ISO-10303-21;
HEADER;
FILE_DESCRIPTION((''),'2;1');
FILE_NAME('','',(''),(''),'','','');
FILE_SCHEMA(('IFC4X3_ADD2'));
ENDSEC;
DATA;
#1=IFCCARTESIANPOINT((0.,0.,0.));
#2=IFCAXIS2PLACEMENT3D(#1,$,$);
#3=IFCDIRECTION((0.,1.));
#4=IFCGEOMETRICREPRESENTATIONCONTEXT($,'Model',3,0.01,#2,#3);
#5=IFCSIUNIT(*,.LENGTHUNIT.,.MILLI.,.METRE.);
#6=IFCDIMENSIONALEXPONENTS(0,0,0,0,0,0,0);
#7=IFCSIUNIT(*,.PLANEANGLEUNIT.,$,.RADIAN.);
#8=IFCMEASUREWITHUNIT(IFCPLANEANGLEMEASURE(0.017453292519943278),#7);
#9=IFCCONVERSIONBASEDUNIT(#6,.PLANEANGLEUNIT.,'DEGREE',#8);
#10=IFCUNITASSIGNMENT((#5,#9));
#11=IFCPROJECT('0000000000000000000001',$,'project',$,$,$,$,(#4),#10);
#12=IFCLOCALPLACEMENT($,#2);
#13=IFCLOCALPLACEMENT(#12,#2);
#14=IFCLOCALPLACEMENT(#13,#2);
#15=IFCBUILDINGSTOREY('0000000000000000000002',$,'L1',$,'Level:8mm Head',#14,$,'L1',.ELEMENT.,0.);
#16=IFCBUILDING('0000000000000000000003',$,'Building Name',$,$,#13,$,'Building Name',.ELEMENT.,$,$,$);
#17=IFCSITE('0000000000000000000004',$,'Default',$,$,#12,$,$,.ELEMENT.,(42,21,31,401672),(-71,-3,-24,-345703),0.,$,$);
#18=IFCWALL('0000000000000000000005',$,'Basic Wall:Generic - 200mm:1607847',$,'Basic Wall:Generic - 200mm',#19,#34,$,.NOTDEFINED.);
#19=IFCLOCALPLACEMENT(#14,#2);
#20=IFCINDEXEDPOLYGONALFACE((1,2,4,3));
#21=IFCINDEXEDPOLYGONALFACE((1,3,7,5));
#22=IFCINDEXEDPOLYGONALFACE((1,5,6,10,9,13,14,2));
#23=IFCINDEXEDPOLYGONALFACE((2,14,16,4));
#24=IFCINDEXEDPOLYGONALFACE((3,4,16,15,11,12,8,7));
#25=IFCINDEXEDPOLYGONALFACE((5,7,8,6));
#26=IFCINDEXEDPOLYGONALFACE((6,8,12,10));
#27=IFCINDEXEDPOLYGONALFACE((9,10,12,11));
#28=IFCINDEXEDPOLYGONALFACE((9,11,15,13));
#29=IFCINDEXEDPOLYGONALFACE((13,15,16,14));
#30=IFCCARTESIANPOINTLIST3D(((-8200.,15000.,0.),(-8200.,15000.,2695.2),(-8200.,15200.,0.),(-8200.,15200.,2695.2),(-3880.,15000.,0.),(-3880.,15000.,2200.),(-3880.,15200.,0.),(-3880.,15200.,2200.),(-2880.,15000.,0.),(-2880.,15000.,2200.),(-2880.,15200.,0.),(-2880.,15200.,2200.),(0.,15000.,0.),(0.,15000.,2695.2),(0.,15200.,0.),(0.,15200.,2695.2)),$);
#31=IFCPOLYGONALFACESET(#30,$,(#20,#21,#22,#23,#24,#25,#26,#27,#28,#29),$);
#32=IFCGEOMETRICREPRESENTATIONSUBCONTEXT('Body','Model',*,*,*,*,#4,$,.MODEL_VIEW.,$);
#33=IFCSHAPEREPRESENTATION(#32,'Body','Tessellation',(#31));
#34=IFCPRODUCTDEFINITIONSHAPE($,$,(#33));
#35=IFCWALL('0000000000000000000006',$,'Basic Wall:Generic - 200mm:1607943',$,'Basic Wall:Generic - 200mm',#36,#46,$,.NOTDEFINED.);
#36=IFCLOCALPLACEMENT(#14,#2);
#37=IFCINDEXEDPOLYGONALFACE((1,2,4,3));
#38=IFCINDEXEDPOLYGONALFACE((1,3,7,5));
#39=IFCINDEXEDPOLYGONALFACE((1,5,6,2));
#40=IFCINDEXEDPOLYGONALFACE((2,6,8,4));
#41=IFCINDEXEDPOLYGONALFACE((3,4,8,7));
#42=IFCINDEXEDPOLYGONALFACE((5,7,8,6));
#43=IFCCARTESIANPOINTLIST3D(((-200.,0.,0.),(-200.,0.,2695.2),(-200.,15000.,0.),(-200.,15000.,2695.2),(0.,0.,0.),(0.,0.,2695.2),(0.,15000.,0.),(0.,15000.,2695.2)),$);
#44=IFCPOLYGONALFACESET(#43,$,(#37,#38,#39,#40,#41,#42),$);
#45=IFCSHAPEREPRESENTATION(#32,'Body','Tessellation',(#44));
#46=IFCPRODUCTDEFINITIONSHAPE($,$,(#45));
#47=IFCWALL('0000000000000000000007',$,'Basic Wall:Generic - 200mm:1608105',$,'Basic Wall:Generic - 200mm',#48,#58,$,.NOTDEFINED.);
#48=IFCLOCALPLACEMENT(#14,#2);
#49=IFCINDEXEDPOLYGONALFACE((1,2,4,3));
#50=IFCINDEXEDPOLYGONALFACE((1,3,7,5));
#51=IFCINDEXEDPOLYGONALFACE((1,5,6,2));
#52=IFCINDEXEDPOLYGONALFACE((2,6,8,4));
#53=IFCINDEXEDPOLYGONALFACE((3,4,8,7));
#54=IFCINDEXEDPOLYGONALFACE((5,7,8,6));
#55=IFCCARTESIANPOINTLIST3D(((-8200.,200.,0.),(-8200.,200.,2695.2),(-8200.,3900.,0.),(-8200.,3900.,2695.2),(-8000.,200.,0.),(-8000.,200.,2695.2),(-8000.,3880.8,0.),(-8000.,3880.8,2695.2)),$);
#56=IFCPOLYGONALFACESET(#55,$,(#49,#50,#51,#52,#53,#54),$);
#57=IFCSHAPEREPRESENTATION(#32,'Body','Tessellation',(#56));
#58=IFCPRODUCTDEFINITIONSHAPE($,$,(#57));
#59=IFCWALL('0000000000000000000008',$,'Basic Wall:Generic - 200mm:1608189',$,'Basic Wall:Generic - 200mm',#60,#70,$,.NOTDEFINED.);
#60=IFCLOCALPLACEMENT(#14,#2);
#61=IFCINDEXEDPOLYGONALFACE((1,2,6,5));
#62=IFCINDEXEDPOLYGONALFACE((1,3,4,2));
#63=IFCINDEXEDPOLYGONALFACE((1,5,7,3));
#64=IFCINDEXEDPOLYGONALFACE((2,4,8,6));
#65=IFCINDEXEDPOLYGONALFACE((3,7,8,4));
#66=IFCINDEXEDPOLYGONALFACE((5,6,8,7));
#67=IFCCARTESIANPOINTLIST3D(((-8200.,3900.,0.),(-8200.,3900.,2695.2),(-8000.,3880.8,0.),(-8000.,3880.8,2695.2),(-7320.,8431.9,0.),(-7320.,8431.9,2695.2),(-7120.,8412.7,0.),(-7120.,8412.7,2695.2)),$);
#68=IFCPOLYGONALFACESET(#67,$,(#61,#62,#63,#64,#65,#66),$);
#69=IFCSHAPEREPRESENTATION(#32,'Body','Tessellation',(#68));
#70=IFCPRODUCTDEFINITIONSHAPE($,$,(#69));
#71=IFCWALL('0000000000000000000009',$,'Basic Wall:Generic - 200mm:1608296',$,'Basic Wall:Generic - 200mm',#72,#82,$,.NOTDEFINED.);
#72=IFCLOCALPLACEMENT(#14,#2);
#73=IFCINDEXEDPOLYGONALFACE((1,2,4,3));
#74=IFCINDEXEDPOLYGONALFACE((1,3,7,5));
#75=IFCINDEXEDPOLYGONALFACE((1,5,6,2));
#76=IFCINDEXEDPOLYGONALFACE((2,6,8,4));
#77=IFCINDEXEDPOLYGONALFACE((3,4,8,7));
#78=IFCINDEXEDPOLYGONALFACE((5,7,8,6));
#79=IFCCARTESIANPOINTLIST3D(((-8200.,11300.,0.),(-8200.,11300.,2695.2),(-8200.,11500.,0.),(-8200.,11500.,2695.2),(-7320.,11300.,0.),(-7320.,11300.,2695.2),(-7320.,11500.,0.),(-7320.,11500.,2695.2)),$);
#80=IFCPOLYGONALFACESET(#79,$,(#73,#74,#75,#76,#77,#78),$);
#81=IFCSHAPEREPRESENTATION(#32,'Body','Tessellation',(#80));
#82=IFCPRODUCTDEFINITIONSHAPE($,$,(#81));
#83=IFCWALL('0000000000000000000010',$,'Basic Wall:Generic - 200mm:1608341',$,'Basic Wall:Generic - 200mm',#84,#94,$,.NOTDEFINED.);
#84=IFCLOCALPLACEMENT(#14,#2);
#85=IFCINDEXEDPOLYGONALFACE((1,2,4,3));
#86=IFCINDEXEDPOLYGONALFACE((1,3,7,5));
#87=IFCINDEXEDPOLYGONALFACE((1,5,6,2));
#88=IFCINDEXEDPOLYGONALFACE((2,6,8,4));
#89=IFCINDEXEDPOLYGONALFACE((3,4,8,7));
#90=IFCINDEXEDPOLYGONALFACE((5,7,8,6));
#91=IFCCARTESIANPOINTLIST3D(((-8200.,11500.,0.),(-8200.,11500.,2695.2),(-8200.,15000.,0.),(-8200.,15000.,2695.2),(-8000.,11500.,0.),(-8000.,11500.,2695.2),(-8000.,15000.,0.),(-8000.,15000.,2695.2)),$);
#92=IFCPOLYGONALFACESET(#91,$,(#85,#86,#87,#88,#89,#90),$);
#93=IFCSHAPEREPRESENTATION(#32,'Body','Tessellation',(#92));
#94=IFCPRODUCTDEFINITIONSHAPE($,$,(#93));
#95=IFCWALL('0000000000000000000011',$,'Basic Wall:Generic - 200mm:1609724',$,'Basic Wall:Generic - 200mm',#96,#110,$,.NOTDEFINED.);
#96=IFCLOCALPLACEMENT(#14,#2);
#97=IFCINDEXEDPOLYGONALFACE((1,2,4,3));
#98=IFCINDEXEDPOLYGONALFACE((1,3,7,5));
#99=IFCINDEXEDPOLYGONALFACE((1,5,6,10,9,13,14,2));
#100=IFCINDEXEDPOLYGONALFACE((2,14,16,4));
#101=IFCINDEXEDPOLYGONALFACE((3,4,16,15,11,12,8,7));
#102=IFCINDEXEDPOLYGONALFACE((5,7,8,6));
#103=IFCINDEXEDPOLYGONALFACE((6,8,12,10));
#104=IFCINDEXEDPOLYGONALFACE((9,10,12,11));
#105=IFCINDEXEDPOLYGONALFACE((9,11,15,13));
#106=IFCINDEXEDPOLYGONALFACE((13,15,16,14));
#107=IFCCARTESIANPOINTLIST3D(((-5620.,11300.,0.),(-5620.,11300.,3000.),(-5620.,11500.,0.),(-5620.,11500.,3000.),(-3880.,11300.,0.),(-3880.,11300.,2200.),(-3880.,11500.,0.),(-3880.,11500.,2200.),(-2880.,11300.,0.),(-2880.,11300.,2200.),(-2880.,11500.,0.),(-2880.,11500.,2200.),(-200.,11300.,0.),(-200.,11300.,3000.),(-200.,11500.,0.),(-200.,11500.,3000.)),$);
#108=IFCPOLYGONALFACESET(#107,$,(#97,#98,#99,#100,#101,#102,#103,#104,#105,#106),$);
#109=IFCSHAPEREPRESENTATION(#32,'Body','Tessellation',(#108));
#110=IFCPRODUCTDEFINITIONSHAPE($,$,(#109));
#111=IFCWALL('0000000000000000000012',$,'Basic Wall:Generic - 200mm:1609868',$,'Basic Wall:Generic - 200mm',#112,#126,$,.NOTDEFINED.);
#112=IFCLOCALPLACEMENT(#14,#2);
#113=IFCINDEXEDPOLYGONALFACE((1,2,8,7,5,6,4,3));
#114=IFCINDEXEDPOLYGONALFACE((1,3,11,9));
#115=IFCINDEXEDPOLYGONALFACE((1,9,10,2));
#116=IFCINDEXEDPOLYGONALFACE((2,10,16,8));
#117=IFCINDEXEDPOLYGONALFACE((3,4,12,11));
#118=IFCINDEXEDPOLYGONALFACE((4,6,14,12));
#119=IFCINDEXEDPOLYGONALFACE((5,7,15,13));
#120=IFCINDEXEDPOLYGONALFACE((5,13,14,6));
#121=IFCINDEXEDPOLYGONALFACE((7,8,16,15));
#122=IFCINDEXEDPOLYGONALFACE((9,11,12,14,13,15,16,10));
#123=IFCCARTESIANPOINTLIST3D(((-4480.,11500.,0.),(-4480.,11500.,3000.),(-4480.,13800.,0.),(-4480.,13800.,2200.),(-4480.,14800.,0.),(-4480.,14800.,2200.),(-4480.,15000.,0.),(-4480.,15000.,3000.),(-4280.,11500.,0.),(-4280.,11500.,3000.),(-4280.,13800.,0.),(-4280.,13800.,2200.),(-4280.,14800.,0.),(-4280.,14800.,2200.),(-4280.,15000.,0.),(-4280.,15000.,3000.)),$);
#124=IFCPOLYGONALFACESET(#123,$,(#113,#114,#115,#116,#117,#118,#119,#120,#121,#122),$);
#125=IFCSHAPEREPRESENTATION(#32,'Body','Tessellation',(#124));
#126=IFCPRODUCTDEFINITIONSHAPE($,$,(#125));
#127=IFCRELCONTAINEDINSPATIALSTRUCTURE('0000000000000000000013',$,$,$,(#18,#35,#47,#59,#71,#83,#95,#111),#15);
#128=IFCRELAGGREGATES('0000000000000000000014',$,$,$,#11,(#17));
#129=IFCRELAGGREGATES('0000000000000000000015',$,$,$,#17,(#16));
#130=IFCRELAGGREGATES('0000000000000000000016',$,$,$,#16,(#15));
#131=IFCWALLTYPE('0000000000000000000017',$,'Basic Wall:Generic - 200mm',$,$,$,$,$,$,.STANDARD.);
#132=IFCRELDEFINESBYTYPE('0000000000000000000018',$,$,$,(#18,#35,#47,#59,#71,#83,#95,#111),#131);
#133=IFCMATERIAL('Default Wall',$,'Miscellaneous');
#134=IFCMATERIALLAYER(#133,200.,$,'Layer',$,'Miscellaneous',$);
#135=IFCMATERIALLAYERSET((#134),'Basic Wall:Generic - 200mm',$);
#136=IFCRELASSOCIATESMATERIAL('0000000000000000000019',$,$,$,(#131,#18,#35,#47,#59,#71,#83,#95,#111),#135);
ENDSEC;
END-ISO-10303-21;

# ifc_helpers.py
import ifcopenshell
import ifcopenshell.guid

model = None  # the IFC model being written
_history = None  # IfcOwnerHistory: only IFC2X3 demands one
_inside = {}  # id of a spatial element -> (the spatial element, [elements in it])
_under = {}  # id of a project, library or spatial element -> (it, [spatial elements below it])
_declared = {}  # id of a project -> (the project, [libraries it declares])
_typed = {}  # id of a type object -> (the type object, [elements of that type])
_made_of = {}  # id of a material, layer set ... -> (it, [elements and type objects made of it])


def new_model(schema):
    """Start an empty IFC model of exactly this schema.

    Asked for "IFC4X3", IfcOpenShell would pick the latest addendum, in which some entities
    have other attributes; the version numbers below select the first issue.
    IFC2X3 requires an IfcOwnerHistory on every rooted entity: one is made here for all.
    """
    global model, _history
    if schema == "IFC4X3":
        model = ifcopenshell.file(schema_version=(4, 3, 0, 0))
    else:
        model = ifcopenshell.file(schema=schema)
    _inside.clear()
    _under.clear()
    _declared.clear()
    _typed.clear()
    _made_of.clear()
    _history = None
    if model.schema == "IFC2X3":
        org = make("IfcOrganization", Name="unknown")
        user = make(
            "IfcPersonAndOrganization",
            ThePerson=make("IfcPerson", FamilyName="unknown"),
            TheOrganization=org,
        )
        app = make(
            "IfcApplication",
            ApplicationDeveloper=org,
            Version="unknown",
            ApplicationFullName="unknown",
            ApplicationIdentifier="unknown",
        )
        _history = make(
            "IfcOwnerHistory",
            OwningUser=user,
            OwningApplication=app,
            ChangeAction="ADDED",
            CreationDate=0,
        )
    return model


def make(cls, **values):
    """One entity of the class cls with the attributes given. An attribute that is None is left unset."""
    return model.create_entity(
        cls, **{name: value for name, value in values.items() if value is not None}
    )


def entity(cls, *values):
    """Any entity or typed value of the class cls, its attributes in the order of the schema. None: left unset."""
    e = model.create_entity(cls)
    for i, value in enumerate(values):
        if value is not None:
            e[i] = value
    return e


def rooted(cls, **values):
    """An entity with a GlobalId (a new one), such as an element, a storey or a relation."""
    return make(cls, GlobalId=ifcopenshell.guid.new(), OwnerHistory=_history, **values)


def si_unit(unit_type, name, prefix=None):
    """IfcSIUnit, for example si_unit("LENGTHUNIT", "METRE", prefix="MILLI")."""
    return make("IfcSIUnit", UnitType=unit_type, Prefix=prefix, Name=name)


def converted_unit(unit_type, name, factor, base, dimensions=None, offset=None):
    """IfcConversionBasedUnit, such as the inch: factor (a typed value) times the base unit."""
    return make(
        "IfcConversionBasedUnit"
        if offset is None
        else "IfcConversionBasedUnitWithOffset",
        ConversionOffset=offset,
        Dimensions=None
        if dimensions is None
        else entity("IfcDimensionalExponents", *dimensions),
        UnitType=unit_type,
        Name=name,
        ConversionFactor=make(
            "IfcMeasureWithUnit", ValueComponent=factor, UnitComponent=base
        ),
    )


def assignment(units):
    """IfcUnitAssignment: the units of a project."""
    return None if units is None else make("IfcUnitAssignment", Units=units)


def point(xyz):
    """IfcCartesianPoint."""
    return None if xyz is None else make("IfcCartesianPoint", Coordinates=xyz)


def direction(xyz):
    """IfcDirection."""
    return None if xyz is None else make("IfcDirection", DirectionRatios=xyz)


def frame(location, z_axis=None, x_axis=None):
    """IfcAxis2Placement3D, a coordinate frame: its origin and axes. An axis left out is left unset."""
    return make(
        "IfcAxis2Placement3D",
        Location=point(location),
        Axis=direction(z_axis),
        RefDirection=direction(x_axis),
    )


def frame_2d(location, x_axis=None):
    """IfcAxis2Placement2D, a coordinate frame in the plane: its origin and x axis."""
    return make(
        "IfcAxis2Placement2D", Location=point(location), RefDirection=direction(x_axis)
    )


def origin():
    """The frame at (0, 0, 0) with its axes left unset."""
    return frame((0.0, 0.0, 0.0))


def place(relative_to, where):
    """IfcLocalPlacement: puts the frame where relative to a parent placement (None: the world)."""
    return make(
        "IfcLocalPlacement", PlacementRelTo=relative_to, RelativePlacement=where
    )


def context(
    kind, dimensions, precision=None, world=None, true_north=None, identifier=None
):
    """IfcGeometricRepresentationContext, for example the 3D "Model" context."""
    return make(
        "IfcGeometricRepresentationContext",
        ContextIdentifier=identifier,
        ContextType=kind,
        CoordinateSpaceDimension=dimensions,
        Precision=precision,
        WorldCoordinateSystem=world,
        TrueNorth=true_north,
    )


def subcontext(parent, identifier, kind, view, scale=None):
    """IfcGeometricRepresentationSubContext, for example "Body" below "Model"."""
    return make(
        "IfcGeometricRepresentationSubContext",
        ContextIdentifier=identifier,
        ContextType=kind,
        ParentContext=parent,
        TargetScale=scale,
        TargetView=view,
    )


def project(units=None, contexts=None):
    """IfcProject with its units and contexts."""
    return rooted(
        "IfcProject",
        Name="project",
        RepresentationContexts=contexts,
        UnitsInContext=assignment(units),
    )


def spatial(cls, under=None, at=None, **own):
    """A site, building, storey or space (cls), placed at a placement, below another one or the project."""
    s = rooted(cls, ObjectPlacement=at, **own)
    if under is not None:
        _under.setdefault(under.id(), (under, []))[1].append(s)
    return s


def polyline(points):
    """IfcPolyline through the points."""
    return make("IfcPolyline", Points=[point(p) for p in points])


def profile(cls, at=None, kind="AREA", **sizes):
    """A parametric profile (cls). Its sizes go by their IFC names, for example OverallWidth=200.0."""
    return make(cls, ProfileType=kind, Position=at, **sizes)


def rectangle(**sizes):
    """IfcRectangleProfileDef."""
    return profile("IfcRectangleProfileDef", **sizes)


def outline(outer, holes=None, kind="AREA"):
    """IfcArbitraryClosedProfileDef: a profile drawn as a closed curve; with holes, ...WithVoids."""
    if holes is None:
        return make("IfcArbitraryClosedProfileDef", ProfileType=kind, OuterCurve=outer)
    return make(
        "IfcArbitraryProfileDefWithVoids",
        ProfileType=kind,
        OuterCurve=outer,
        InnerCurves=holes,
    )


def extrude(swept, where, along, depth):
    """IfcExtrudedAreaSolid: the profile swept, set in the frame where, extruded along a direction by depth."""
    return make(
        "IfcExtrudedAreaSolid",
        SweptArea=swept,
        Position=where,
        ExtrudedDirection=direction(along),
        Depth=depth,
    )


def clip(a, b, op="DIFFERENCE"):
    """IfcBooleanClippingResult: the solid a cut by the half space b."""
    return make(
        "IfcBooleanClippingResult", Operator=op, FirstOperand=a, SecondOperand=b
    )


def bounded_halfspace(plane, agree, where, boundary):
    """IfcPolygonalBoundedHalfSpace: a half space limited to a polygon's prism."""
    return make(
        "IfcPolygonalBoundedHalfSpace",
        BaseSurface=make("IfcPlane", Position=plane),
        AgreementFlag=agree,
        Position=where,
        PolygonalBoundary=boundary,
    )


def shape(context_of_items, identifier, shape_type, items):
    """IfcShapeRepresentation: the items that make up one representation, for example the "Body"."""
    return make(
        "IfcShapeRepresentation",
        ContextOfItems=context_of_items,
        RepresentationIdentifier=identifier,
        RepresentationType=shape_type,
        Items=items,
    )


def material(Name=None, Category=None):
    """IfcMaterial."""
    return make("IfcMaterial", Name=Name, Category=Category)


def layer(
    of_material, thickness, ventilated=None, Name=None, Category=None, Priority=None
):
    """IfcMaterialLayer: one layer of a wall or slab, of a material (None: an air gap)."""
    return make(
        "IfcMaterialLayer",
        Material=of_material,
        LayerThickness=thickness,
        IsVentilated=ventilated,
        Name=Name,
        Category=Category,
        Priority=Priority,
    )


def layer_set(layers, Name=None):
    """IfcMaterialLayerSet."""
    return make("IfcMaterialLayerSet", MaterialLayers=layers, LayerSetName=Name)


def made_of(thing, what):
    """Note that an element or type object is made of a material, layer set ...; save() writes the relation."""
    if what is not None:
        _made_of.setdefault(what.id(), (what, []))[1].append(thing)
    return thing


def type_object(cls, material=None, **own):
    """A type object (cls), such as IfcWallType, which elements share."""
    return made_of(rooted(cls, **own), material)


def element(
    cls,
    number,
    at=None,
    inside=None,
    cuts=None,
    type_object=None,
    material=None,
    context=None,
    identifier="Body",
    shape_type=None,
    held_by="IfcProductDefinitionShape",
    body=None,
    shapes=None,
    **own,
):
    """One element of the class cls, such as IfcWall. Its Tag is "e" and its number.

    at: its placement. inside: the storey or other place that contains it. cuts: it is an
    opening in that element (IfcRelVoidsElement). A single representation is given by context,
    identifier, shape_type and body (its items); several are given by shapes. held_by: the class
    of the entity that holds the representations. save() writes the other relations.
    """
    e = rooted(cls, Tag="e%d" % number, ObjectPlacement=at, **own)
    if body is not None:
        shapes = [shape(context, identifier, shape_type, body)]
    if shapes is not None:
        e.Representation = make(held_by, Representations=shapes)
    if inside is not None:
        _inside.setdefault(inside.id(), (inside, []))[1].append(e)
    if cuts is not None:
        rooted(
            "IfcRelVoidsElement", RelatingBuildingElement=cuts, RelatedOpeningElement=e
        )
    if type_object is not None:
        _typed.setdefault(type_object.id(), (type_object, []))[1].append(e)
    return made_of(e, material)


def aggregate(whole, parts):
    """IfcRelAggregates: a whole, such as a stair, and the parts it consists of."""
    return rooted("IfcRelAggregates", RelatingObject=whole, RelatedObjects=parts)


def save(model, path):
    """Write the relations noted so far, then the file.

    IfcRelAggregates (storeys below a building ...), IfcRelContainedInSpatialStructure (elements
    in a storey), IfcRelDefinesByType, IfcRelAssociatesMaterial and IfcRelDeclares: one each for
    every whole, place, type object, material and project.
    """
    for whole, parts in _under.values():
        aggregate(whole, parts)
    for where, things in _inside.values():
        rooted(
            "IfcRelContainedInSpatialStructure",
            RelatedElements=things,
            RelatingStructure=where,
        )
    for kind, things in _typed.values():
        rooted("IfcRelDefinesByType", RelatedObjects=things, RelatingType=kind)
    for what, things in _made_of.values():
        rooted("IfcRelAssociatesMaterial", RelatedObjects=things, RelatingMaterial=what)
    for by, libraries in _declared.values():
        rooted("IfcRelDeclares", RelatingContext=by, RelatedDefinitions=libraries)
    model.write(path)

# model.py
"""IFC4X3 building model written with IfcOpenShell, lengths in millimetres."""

from ifc_helpers import new_model, entity, si_unit, converted_unit, direction, frame, frame_2d, origin, place, context, subcontext, project, spatial, polyline, rectangle, outline, extrude, clip, bounded_halfspace, material, layer, layer_set, type_object, element, save


model = new_model("IFC4X3")

# Units and contexts
model_context = context("Model", 3, precision=0.01, world=origin(), true_north=direction((0.0, 1.0)))
body_context = subcontext(model_context, "Body", "Model", "MODEL_VIEW")
ifc_project = project(units=[si_unit("LENGTHUNIT", "METRE", prefix="MILLI"), converted_unit("PLANEANGLEUNIT", "DEGREE", entity("IfcPlaneAngleMeasure", 0.017453292519943278), si_unit("PLANEANGLEUNIT", "RADIAN"), dimensions=[0, 0, 0, 0, 0, 0, 0])], contexts=[model_context])

# Site, building, storey
site_placement = place(None, origin())
site = spatial("IfcSite", under=ifc_project, at=site_placement, Name="Default", CompositionType="ELEMENT", RefLatitude=(42, 21, 31, 401672), RefLongitude=(-71, -3, -24, -345703), RefElevation=0.0)
building_placement = place(site_placement, origin())
building = spatial("IfcBuilding", under=site, at=building_placement, Name="Building Name", LongName="Building Name", CompositionType="ELEMENT")
storey_placement = place(building_placement, origin())
storey = spatial("IfcBuildingStorey", under=building, at=storey_placement, Name="L1", ObjectType="Level:8mm Head", LongName="L1", CompositionType="ELEMENT", Elevation=0.0)

# Wall, opening
ifc_material = material(Name="Default Wall", Category="Miscellaneous")
ifc_layer = layer(ifc_material, 200.0, Name="Layer", Category="Miscellaneous")
ifc_layer_set = layer_set([ifc_layer], Name="Basic Wall:Generic - 200mm")
wall_type = type_object("IfcWallType", Name="Basic Wall:Generic - 200mm", PredefinedType="STANDARD", material=ifc_layer_set)
wall_1_placement = place(storey_placement, frame((-8200.0, 15100.0, 0.0)))
wall_1 = element("IfcWall", 1, at=wall_1_placement, inside=storey, type_object=wall_type, material=ifc_layer_set, Name="Basic Wall:Generic - 200mm:1607847", ObjectType="Basic Wall:Generic - 200mm", PredefinedType="NOTDEFINED", context=body_context, shape_type="Clipping", body=[
    clip(extrude(rectangle(XDim=8200.0, YDim=200.0, at=frame_2d((4100.0, 0.0), x_axis=(1.0, 0.0))), origin(), (0.0, 0.0, 1.0), 2695.2), bounded_halfspace(frame((0.0, -100.0, 2695.2), z_axis=(0.0, 0.0, -1.0), x_axis=(0.0, 1.0, 0.0)), True, frame((0.0, -100.0, 2695.2)), polyline([(0.0, 0.0), (200.0, 0.0), (8000.0, 0.0), (8200.0, 0.0), (8200.0, 200.0), (0.0, 200.0), (0.0, 0.0)]))),
])
opening_1_placement = place(wall_1_placement, frame((5320.0, 100.0, 0.0)))
element("IfcOpeningElement", 2, at=opening_1_placement, cuts=wall_1, PredefinedType="OPENING", context=body_context, shape_type="SweptSolid", body=[
    extrude(rectangle(XDim=2200.0, YDim=1000.0, at=frame_2d((1100.0, 500.0), x_axis=(1.0, 0.0))), frame((0.0, 0.0, 0.0), z_axis=(0.0, -1.0, 0.0), x_axis=(0.0, 0.0, 1.0)), (0.0, 0.0, 1.0), 200.0),
])

# Wall
wall_2_placement = place(storey_placement, frame((-100.0, 15000.0, 0.0), z_axis=(0.0, 0.0, 1.0), x_axis=(0.0, -1.0, 0.0)))
element("IfcWall", 3, at=wall_2_placement, inside=storey, type_object=wall_type, material=ifc_layer_set, Name="Basic Wall:Generic - 200mm:1607943", ObjectType="Basic Wall:Generic - 200mm", PredefinedType="NOTDEFINED", context=body_context, shape_type="Clipping", body=[
    clip(extrude(rectangle(XDim=15000.0, YDim=200.0, at=frame_2d((7500.0, 0.0), x_axis=(-1.0, 0.0))), origin(), (0.0, 0.0, 1.0), 2695.2), bounded_halfspace(frame((0.0, -100.0, 2695.2), z_axis=(0.0, 0.0, -1.0), x_axis=(-1.0, 0.0, 0.0)), True, frame((0.0, -100.0, 2695.2)), polyline([(0.0, 0.0), (14800.0, 0.0), (15000.0, 0.0), (15000.0, 200.0), (0.0, 200.0), (0.0, 0.0)]))),
])

# Walls
wall_3_placement = place(storey_placement, frame((-8100.0, 3900.0, 0.0), z_axis=(0.0, 0.0, 1.0), x_axis=(0.0, -1.0, 0.0)))
element("IfcWall", 4, at=wall_3_placement, inside=storey, type_object=wall_type, material=ifc_layer_set, Name="Basic Wall:Generic - 200mm:1608105", ObjectType="Basic Wall:Generic - 200mm", PredefinedType="NOTDEFINED", context=body_context, shape_type="Clipping", body=[
    clip(extrude(outline(polyline([(3700.0, -100.0), (3700.0, 100.0), (19.2, 100.0), (0.0, -100.0), (3700.0, -100.0)])), origin(), (0.0, 0.0, 1.0), 2695.2), bounded_halfspace(frame((0.0, -100.0, 2695.2), z_axis=(0.0, 0.0, -1.0), x_axis=(-1.0, 0.0, 0.0)), True, frame((0.0, -100.0, 2695.2)), polyline([(0.0, 0.0), (3700.0, 0.0), (3700.0, 200.0), (19.2, 200.0), (0.0, 0.0)]))),
])
wall_4_placement = place(storey_placement, frame((-8101.8, 3880.9, 0.0), z_axis=(0.0, 0.0, 1.0), x_axis=(0.190619, 0.981664, 0.0)))
element("IfcWall", 5, at=wall_4_placement, inside=storey, type_object=wall_type, material=ifc_layer_set, Name="Basic Wall:Generic - 200mm:1608189", ObjectType="Basic Wall:Generic - 200mm", PredefinedType="NOTDEFINED", context=body_context, shape_type="Clipping", body=[
    clip(extrude(outline(polyline([(4635.8, -100.0), (4616.5, 100.0), (0.0, 100.0), (19.2, -100.0), (4635.8, -100.0)])), origin(), (0.0, 0.0, 1.0), 2695.2), bounded_halfspace(frame((19.2, -100.0, 2695.2), z_axis=(0.0, 0.0, -1.0), x_axis=(0.981664, 0.190619, 0.0)), True, frame((19.2, -100.0, 2695.2)), polyline([(0.0, 0.0), (4616.5, 0.0), (4597.3, 200.0), (-19.2, 200.0), (0.0, 0.0)]))),
])
wall_5_placement = place(storey_placement, frame((-7320.0, 11400.0, 0.0), z_axis=(0.0, 0.0, 1.0), x_axis=(-1.0, 0.0, 0.0)))
element("IfcWall", 6, at=wall_5_placement, inside=storey, type_object=wall_type, material=ifc_layer_set, Name="Basic Wall:Generic - 200mm:1608296", ObjectType="Basic Wall:Generic - 200mm", PredefinedType="NOTDEFINED", context=body_context, shape_type="Clipping", body=[
    clip(extrude(rectangle(XDim=880.0, YDim=200.0, at=frame_2d((440.0, 0.0), x_axis=(-1.0, 0.0))), origin(), (0.0, 0.0, 1.0), 2695.2), bounded_halfspace(frame((0.0, -100.0, 2695.2), z_axis=(0.0, 0.0, -1.0), x_axis=(0.0, -1.0, 0.0)), True, frame((0.0, -100.0, 2695.2)), polyline([(0.0, 0.0), (680.0, 0.0), (880.0, 0.0), (880.0, 200.0), (0.0, 200.0), (0.0, 0.0)]))),
])
wall_6_placement = place(storey_placement, frame((-8100.0, 11500.0, 0.0), z_axis=(0.0, 0.0, 1.0), x_axis=(0.0, 1.0, 0.0)))
element("IfcWall", 7, at=wall_6_placement, inside=storey, type_object=wall_type, material=ifc_layer_set, Name="Basic Wall:Generic - 200mm:1608341", ObjectType="Basic Wall:Generic - 200mm", PredefinedType="NOTDEFINED", context=body_context, shape_type="Clipping", body=[
    clip(extrude(rectangle(XDim=3500.0, YDim=200.0, at=frame_2d((1750.0, 0.0), x_axis=(-1.0, 0.0))), origin(), (0.0, 0.0, 1.0), 2695.2), bounded_halfspace(frame((0.0, -100.0, 2695.2), z_axis=(0.0, 0.0, -1.0), x_axis=(1.0, 0.0, 0.0)), True, frame((0.0, -100.0, 2695.2)), polyline([(0.0, 0.0), (3500.0, 0.0), (3500.0, 200.0), (0.0, 200.0), (0.0, 0.0)]))),
])

# Walls, openings
wall_7_placement = place(storey_placement, frame((-5620.0, 11400.0, 0.0)))
wall_7 = element("IfcWall", 8, at=wall_7_placement, inside=storey, type_object=wall_type, material=ifc_layer_set, Name="Basic Wall:Generic - 200mm:1609724", ObjectType="Basic Wall:Generic - 200mm", PredefinedType="NOTDEFINED", context=body_context, shape_type="SweptSolid", body=[
    extrude(rectangle(XDim=5420.0, YDim=200.0, at=frame_2d((2710.0, 0.0), x_axis=(-1.0, 0.0))), origin(), (0.0, 0.0, 1.0), 3000.0),
])
opening_2_placement = place(wall_7_placement, frame((1740.0, -100.0, 0.0)))
element("IfcOpeningElement", 9, at=opening_2_placement, cuts=wall_7, PredefinedType="OPENING", context=body_context, shape_type="SweptSolid", body=[
    extrude(rectangle(XDim=2200.0, YDim=1000.0, at=frame_2d((1100.0, 500.0), x_axis=(1.0, 0.0))), frame((0.0, 0.0, 0.0), z_axis=(0.0, 1.0, 0.0), x_axis=(0.0, 0.0, 1.0)), (0.0, 0.0, 1.0), 200.0),
])
wall_8_placement = place(storey_placement, frame((-4380.0, 11500.0, 0.0), z_axis=(0.0, 0.0, 1.0), x_axis=(0.0, 1.0, 0.0)))
wall_8 = element("IfcWall", 10, at=wall_8_placement, inside=storey, type_object=wall_type, material=ifc_layer_set, Name="Basic Wall:Generic - 200mm:1609868", ObjectType="Basic Wall:Generic - 200mm", PredefinedType="NOTDEFINED", context=body_context, shape_type="SweptSolid", body=[
    extrude(rectangle(XDim=3500.0, YDim=200.0, at=frame_2d((1750.0, 0.0), x_axis=(-1.0, 0.0))), origin(), (0.0, 0.0, 1.0), 3000.0),
])
opening_3_placement = place(wall_8_placement, frame((2300.0, -100.0, 0.0)))
element("IfcOpeningElement", 11, at=opening_3_placement, cuts=wall_8, PredefinedType="OPENING", context=body_context, shape_type="SweptSolid", body=[
    extrude(rectangle(XDim=2200.0, YDim=1000.0, at=frame_2d((1100.0, 500.0), x_axis=(1.0, 0.0))), frame((0.0, 0.0, 0.0), z_axis=(0.0, 1.0, 0.0), x_axis=(0.0, 0.0, 1.0)), (0.0, 0.0, 1.0), 200.0),
])

save(model, "model.ifc")
